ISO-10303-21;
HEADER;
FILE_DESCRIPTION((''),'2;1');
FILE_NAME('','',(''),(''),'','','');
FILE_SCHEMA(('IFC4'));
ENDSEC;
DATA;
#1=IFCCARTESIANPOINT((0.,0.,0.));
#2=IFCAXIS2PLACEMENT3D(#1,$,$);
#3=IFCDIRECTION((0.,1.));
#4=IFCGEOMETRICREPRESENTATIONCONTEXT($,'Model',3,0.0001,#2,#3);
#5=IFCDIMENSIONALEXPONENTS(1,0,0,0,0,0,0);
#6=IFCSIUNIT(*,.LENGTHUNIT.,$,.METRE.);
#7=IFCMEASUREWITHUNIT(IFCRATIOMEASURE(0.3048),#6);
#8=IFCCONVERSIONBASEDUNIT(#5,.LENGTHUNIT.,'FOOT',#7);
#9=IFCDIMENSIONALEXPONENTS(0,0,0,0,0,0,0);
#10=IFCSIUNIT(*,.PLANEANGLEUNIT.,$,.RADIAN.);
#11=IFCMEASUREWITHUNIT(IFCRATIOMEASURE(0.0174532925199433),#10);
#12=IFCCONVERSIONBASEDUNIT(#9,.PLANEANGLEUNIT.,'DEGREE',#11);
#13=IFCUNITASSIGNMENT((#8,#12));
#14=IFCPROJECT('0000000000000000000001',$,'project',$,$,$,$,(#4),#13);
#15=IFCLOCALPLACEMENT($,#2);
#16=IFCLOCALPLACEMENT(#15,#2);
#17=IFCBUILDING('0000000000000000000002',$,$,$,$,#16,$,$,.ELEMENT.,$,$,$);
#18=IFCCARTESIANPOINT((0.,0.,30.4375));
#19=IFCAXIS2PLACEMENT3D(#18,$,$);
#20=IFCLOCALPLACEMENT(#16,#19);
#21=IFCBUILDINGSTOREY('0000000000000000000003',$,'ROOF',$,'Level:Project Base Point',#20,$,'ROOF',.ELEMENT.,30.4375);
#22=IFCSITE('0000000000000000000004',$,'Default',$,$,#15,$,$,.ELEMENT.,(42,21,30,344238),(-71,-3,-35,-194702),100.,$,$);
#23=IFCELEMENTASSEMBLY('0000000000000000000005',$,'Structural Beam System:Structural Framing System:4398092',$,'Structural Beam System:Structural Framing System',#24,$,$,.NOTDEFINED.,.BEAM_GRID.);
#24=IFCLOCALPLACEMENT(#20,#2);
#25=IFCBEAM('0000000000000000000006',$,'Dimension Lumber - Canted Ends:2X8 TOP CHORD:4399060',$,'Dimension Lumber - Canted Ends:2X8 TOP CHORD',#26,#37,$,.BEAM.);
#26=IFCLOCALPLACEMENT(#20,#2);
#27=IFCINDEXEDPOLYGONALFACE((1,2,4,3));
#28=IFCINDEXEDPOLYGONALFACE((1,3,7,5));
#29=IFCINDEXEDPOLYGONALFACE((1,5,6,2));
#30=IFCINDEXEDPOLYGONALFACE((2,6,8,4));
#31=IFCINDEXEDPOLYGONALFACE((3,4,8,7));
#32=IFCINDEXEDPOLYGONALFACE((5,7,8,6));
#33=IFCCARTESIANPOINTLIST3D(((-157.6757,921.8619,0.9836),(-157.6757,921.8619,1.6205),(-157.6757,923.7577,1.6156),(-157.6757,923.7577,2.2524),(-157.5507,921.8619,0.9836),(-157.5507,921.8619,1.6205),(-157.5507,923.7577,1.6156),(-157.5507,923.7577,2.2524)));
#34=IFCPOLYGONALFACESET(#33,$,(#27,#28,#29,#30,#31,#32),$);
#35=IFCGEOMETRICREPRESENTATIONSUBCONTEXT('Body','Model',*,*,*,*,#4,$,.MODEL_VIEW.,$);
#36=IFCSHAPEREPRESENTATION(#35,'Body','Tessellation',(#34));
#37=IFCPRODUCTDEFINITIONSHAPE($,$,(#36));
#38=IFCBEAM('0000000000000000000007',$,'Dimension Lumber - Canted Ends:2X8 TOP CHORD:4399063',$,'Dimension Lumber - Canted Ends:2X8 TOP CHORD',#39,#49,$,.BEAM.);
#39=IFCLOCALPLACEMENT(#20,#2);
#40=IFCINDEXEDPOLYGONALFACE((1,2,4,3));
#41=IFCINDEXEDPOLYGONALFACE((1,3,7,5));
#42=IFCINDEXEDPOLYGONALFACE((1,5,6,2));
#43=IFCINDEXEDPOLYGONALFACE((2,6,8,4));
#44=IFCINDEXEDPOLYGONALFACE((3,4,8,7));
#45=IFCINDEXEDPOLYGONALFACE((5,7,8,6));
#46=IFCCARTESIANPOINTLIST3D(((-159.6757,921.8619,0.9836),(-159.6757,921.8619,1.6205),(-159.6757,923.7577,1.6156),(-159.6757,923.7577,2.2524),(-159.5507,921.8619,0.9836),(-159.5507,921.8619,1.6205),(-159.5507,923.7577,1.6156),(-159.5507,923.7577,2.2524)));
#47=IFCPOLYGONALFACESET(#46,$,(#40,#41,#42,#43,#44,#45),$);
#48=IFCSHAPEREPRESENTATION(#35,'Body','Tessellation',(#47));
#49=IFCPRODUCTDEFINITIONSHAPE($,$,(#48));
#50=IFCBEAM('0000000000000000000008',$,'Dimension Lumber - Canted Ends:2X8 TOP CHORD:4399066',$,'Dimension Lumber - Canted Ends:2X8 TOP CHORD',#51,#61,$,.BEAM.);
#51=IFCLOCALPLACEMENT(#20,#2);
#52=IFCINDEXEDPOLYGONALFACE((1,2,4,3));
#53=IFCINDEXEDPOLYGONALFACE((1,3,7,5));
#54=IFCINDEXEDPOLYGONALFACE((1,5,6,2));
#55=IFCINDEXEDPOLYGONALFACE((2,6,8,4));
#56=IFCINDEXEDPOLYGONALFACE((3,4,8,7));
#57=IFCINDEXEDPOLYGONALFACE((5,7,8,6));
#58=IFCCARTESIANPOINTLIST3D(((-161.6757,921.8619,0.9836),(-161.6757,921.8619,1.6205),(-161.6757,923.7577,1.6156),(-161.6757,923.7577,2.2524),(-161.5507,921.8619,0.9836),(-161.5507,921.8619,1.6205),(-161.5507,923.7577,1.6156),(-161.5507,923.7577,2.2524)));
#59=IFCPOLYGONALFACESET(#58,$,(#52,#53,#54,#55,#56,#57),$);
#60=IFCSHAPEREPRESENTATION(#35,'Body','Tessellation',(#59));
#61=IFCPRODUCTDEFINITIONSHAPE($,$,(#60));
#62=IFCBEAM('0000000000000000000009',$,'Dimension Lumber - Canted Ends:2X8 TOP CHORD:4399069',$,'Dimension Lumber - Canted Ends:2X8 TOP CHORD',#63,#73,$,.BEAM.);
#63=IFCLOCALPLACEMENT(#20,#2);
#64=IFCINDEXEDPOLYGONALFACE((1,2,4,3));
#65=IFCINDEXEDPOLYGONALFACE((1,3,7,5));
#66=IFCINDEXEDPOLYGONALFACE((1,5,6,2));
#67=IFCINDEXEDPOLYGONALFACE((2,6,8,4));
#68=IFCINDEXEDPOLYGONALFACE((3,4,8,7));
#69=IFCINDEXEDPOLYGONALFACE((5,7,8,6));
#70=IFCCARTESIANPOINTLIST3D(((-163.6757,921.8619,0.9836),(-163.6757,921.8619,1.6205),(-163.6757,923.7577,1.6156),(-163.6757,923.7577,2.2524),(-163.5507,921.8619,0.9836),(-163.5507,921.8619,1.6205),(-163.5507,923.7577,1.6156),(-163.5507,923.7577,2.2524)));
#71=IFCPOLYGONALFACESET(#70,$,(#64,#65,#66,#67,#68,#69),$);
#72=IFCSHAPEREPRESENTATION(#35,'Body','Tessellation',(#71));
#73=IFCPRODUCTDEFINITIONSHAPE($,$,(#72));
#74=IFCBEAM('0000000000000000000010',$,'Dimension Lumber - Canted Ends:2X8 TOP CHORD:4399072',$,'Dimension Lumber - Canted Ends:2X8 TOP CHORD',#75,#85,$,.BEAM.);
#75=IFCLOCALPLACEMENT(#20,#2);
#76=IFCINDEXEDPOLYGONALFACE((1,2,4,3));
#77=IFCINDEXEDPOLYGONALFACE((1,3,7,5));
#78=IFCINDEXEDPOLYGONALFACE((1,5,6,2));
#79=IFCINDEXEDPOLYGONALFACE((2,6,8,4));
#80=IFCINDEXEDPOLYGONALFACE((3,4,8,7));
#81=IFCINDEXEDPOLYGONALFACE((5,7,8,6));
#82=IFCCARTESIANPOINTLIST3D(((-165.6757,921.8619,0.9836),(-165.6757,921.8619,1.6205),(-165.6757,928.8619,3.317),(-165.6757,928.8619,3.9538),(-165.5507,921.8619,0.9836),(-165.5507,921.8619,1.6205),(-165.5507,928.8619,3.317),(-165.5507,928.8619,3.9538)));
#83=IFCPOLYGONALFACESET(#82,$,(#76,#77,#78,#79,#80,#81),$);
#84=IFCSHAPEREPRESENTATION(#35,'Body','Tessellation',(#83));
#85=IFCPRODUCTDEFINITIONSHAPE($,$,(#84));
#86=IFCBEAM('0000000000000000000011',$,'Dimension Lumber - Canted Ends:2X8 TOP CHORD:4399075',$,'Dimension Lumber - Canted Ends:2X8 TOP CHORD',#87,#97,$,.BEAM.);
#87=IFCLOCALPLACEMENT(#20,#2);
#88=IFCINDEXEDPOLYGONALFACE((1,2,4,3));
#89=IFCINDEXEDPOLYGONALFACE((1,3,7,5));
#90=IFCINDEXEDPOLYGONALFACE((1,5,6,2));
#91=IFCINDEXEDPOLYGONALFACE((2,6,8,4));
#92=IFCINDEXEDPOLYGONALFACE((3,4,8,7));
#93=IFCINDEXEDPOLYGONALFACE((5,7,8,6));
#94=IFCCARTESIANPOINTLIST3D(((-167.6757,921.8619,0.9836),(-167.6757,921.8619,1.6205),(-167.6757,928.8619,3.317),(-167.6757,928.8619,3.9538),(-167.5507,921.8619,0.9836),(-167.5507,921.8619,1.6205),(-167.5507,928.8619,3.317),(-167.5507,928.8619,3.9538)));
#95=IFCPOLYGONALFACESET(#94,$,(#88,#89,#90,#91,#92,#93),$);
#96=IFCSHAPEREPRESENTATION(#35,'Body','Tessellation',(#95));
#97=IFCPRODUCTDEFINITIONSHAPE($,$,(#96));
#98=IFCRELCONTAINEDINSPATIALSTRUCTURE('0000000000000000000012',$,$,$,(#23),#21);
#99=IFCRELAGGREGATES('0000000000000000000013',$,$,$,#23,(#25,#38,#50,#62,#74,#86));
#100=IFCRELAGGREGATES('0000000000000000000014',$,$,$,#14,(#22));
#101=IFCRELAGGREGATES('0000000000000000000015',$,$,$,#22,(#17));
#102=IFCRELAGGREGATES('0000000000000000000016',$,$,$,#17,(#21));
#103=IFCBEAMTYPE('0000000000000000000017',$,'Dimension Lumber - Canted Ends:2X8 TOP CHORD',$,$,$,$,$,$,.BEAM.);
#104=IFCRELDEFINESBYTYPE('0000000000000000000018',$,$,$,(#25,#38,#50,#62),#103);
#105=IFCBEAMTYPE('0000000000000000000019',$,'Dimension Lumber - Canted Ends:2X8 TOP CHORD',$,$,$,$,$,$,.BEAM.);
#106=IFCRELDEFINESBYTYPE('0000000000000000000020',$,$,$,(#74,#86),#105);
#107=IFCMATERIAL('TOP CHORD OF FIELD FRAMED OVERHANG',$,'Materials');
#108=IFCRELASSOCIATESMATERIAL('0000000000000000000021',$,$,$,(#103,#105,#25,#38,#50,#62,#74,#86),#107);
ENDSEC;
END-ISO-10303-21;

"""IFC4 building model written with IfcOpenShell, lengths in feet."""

from ifc_helpers import new_model, entity, si_unit, converted_unit, direction, frame, origin, origin_2d_with_axis, place, context, subcontext, project, spatial, rectangle, extrude, clip, halfspace, source, transform, mapped, material, material_profile, profile_set, profile_usage, type_object, type_shapes, element, aggregate, save


model = new_model("IFC4")

# Units and contexts
model_context = context("Model", 3, precision=0.0001, world=origin(), true_north=direction((0.0, 1.0)))
body_context = subcontext(model_context, "Body", "Model", "MODEL_VIEW")
ifc_project = project(units=[converted_unit("LENGTHUNIT", "FOOT", entity("IfcRatioMeasure", 0.3048), si_unit("LENGTHUNIT", "METRE"), dimensions=[1, 0, 0, 0, 0, 0, 0]), converted_unit("PLANEANGLEUNIT", "DEGREE", entity("IfcRatioMeasure", 0.0174532925199433), si_unit("PLANEANGLEUNIT", "RADIAN"), dimensions=[0, 0, 0, 0, 0, 0, 0])], contexts=[model_context])

# Site, building, storey
site_placement = place(None, origin())
site = spatial("IfcSite", under=ifc_project, at=site_placement, Name="Default", CompositionType="ELEMENT", RefLatitude=(42, 21, 30, 344238), RefLongitude=(-71, -3, -35, -194702), RefElevation=100.0)
building_placement = place(site_placement, origin())
building = spatial("IfcBuilding", under=site, at=building_placement, CompositionType="ELEMENT")
storey_placement = place(building_placement, frame((0.0, 0.0, 30.4375)))
storey = spatial("IfcBuildingStorey", under=building, at=storey_placement, Name="ROOF", ObjectType="Level:Project Base Point", LongName="ROOF", CompositionType="ELEMENT", Elevation=30.4375)

# Element assembly, beams
assembly_1_placement = place(storey_placement, origin())
assembly_1 = element("IfcElementAssembly", 1, at=assembly_1_placement, inside=storey, Name="Structural Beam System:Structural Framing System:4398092", ObjectType="Structural Beam System:Structural Framing System", AssemblyPlace="NOTDEFINED", PredefinedType="BEAM_GRID")
ifc_material_1 = material(Name="TOP CHORD OF FIELD FRAMED OVERHANG", Category="Materials")
ifc_material_profile_1 = material_profile(ifc_material_1, rectangle(XDim=0.6042, YDim=0.125, at=origin_2d_with_axis()), Name="2X8 TOP CHORD")
ifc_profile_set_1 = profile_set([ifc_material_profile_1], Name="2X8 TOP CHORD")
beam_type_1 = type_object("IfcBeamType", Name="Dimension Lumber - Canted Ends:2X8 TOP CHORD", PredefinedType="BEAM", material=ifc_profile_set_1)
shared_shape_1 = source(origin(), body_context, "Body", "Clipping", [
    clip(clip(extrude(rectangle(XDim=0.6042, YDim=0.125, at=origin_2d_with_axis()), frame((-0.9992, 0.0, 0.0), z_axis=(1.0, 0.0, 0.0), x_axis=(0.0, 0.0, -1.0)), (0.0, 0.0, 1.0), 2.1997), halfspace(frame((0.9992, -0.0625, -0.3021), z_axis=(0.948711, 0.0, -0.316146), x_axis=(0.0, 1.0, 0.0)), False)), halfspace(frame((-0.7979, -0.0625, 0.3021), z_axis=(-0.948711, 0.0, 0.316146), x_axis=(0.0, 1.0, 0.0)), False)),
])
type_shapes(beam_type_1, [shared_shape_1])
ifc_profile_usage_1 = profile_usage(ifc_profile_set_1, cardinal=8)
beam_1_placement = place(assembly_1_placement, frame((-157.6132, 922.7143, 1.5862), z_axis=(0.0, -0.316228, 0.948683), x_axis=(0.0, 0.948683, 0.316228)))
beam_1 = element("IfcBeam", 2, at=beam_1_placement, type_object=beam_type_1, material=ifc_profile_usage_1, Name="Dimension Lumber - Canted Ends:2X8 TOP CHORD:4399060", ObjectType="Dimension Lumber - Canted Ends:2X8 TOP CHORD", PredefinedType="BEAM", context=body_context, shape_type="MappedRepresentation", body=[
    mapped(shared_shape_1, transform((0.0, 0.0, 0.0), scale=1.0)),
])
ifc_profile_usage_2 = profile_usage(ifc_profile_set_1, cardinal=8)
beam_2_placement = place(assembly_1_placement, frame((-159.6132, 922.7143, 1.5862), z_axis=(0.0, -0.316228, 0.948683), x_axis=(0.0, 0.948683, 0.316228)))
beam_2 = element("IfcBeam", 3, at=beam_2_placement, type_object=beam_type_1, material=ifc_profile_usage_2, Name="Dimension Lumber - Canted Ends:2X8 TOP CHORD:4399063", ObjectType="Dimension Lumber - Canted Ends:2X8 TOP CHORD", PredefinedType="BEAM", context=body_context, shape_type="MappedRepresentation", body=[
    mapped(shared_shape_1, transform((0.0, 0.0, 0.0), scale=1.0)),
])
ifc_profile_usage_3 = profile_usage(ifc_profile_set_1, cardinal=8)
beam_3_placement = place(assembly_1_placement, frame((-161.6132, 922.7143, 1.5862), z_axis=(0.0, -0.316228, 0.948683), x_axis=(0.0, 0.948683, 0.316228)))
beam_3 = element("IfcBeam", 4, at=beam_3_placement, type_object=beam_type_1, material=ifc_profile_usage_3, Name="Dimension Lumber - Canted Ends:2X8 TOP CHORD:4399066", ObjectType="Dimension Lumber - Canted Ends:2X8 TOP CHORD", PredefinedType="BEAM", context=body_context, shape_type="MappedRepresentation", body=[
    mapped(shared_shape_1, transform((0.0, 0.0, 0.0), scale=1.0)),
])
ifc_profile_usage_4 = profile_usage(ifc_profile_set_1, cardinal=8)
beam_4_placement = place(assembly_1_placement, frame((-163.6132, 922.7143, 1.5862), z_axis=(0.0, -0.316228, 0.948683), x_axis=(0.0, 0.948683, 0.316228)))
beam_4 = element("IfcBeam", 5, at=beam_4_placement, type_object=beam_type_1, material=ifc_profile_usage_4, Name="Dimension Lumber - Canted Ends:2X8 TOP CHORD:4399069", ObjectType="Dimension Lumber - Canted Ends:2X8 TOP CHORD", PredefinedType="BEAM", context=body_context, shape_type="MappedRepresentation", body=[
    mapped(shared_shape_1, transform((0.0, 0.0, 0.0), scale=1.0)),
])
ifc_profile_usage_5 = profile_usage(ifc_profile_set_1, cardinal=8)
beam_type_2 = type_object("IfcBeamType", Name="Dimension Lumber - Canted Ends:2X8 TOP CHORD", PredefinedType="BEAM", material=ifc_profile_set_1)
shared_shape_2 = source(origin(), body_context, "Body", "Clipping", [
    clip(clip(extrude(rectangle(XDim=0.6042, YDim=0.125, at=origin_2d_with_axis()), frame((-3.6893, 0.0, 0.0), z_axis=(1.0, 0.0, 0.0), x_axis=(0.0, 0.0, -1.0)), (0.0, 0.0, 1.0), 7.58), halfspace(frame((3.6893, -0.0625, -0.3021), z_axis=(0.948711, 0.0, -0.316146), x_axis=(0.0, 1.0, 0.0)), False)), halfspace(frame((-3.488, -0.0625, 0.3021), z_axis=(-0.948711, 0.0, 0.316146), x_axis=(0.0, 1.0, 0.0)), False)),
])
type_shapes(beam_type_2, [shared_shape_2])
beam_5_placement = place(assembly_1_placement, frame((-165.6132, 925.2664, 2.4369), z_axis=(0.0, -0.316228, 0.948683), x_axis=(0.0, 0.948683, 0.316228)))
beam_5 = element("IfcBeam", 6, at=beam_5_placement, type_object=beam_type_2, material=ifc_profile_usage_5, Name="Dimension Lumber - Canted Ends:2X8 TOP CHORD:4399072", ObjectType="Dimension Lumber - Canted Ends:2X8 TOP CHORD", PredefinedType="BEAM", context=body_context, shape_type="MappedRepresentation", body=[
    mapped(shared_shape_2, transform((0.0, 0.0, 0.0), scale=1.0)),
])
ifc_profile_usage_6 = profile_usage(ifc_profile_set_1, cardinal=8)
beam_6_placement = place(assembly_1_placement, frame((-167.6132, 925.2664, 2.4369), z_axis=(0.0, -0.316228, 0.948683), x_axis=(0.0, 0.948683, 0.316228)))
beam_6 = element("IfcBeam", 7, at=beam_6_placement, type_object=beam_type_2, material=ifc_profile_usage_6, Name="Dimension Lumber - Canted Ends:2X8 TOP CHORD:4399075", ObjectType="Dimension Lumber - Canted Ends:2X8 TOP CHORD", PredefinedType="BEAM", context=body_context, shape_type="MappedRepresentation", body=[
    mapped(shared_shape_2, transform((0.0, 0.0, 0.0), scale=1.0)),
])
aggregate(assembly_1, [beam_1, beam_2, beam_3, beam_4, beam_5, beam_6])

save(model, "model.ifc")
